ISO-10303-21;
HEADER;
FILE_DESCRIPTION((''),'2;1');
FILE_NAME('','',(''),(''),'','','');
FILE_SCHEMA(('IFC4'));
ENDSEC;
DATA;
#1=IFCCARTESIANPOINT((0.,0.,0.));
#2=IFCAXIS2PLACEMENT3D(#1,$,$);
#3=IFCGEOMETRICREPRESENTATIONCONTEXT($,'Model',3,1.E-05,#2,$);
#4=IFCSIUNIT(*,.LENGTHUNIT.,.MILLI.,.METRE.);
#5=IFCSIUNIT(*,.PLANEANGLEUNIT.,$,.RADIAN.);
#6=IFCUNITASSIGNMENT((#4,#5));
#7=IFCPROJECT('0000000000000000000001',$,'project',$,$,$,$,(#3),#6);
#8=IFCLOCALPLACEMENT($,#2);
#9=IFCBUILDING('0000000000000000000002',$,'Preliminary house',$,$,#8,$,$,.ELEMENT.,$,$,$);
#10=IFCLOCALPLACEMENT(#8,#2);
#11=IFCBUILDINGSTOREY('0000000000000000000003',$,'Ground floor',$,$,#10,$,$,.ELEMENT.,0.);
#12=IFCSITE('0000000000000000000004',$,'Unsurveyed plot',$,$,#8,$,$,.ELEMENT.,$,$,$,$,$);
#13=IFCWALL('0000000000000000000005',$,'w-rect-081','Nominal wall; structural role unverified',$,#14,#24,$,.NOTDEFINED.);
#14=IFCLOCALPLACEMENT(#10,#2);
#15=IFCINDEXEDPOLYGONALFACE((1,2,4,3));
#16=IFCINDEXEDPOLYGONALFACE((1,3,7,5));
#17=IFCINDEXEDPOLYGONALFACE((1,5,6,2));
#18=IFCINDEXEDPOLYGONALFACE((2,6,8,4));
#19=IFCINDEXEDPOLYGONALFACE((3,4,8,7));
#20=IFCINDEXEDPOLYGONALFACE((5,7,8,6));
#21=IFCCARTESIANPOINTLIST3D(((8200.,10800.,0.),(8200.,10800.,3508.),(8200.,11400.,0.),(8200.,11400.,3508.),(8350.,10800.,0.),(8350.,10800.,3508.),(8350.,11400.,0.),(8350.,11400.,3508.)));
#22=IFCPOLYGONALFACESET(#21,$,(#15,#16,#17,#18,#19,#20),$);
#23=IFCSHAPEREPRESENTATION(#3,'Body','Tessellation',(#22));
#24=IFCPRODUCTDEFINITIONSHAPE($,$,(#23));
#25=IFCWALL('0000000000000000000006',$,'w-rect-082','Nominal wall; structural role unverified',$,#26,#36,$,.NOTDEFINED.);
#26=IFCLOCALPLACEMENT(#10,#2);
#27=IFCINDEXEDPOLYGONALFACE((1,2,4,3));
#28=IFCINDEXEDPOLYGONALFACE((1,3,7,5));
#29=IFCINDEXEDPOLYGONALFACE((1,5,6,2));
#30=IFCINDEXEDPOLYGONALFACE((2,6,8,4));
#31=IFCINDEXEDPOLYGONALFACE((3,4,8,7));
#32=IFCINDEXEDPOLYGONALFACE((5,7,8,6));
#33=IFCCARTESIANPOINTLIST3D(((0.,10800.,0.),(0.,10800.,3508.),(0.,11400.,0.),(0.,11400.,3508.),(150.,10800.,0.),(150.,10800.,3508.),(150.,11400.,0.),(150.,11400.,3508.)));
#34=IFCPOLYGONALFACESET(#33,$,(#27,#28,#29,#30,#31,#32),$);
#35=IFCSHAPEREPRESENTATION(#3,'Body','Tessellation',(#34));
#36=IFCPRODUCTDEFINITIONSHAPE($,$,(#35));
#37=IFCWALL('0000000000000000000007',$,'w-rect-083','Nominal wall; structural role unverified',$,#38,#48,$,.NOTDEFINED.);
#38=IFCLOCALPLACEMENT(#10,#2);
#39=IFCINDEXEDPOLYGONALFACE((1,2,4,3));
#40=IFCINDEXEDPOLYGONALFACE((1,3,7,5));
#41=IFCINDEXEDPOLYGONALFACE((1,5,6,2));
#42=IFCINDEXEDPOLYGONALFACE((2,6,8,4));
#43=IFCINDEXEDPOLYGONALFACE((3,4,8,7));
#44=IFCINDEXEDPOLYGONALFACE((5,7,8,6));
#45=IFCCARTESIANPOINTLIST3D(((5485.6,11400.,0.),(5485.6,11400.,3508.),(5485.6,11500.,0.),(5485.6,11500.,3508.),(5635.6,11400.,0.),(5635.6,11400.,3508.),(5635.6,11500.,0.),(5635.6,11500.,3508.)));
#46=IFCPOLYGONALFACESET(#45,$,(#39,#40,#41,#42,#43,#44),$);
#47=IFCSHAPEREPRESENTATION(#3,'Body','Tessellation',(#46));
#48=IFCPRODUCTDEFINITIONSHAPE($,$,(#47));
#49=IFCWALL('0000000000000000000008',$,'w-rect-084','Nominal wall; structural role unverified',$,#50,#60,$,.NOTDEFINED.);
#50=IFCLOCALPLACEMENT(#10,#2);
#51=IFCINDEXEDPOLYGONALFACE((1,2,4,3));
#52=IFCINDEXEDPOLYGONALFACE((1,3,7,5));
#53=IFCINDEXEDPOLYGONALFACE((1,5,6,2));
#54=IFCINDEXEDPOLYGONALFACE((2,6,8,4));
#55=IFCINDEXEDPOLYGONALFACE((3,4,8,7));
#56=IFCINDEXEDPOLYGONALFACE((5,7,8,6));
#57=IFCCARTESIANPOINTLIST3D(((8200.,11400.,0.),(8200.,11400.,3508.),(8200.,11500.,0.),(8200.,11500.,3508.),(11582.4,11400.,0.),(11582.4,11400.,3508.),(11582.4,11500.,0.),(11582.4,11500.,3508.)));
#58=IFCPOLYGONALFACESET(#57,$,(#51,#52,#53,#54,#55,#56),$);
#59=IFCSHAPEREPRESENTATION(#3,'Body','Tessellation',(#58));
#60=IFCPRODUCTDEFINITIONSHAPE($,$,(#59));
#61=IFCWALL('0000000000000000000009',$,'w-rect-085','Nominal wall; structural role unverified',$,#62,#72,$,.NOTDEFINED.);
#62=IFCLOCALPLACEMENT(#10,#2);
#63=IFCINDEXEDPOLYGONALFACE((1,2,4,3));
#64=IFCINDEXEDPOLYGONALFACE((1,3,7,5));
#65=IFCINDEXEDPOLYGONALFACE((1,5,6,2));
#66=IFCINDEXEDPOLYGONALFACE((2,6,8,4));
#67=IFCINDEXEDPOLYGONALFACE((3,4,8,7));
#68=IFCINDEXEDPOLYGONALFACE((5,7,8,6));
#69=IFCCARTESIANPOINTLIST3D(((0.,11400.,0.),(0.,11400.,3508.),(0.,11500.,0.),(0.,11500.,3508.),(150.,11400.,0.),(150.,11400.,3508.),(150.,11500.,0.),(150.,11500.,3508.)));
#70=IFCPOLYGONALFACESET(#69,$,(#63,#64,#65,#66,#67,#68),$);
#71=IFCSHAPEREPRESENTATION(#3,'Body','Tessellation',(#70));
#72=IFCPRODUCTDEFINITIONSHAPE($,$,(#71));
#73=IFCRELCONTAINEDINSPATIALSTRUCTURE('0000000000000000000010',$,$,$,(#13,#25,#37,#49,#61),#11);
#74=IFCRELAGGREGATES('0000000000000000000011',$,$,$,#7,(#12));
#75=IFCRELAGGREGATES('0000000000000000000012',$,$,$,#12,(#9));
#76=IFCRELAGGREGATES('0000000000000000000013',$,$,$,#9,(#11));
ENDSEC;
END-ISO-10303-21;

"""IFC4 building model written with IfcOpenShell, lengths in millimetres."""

from ifc_helpers import new_model, si_unit, origin, place, context, project, spatial, polyline, outline, extrude, element, save


model = new_model("IFC4")

# Units and contexts
model_context = context("Model", 3, precision=1e-05, world=origin())
ifc_project = project(units=[si_unit("LENGTHUNIT", "METRE", prefix="MILLI"), si_unit("PLANEANGLEUNIT", "RADIAN")], contexts=[model_context])

# Site, building, storey
placement_1 = place(None, origin())
site = spatial("IfcSite", under=ifc_project, at=placement_1, Name="Unsurveyed plot", CompositionType="ELEMENT")
building = spatial("IfcBuilding", under=site, at=placement_1, Name="Preliminary house", CompositionType="ELEMENT")
placement_2 = place(placement_1, origin())
storey = spatial("IfcBuildingStorey", under=building, at=placement_2, Name="Ground floor", CompositionType="ELEMENT", Elevation=0.0)

# Walls
element("IfcWall", 1, at=placement_2, inside=storey, Name="w-rect-081", Description="Nominal wall; structural role unverified", PredefinedType="NOTDEFINED", context=model_context, shape_type="SweptSolid", body=[
    extrude(outline(polyline([(8200.0, 10800.0), (8350.0, 10800.0), (8350.0, 11400.0), (8200.0, 11400.0), (8200.0, 10800.0)])), origin(), (0.0, 0.0, 1.0), 3508.0),
])
element("IfcWall", 2, at=placement_2, inside=storey, Name="w-rect-082", Description="Nominal wall; structural role unverified", PredefinedType="NOTDEFINED", context=model_context, shape_type="SweptSolid", body=[
    extrude(outline(polyline([(0.0, 10800.0), (150.0, 10800.0), (150.0, 11400.0), (0.0, 11400.0), (0.0, 10800.0)])), origin(), (0.0, 0.0, 1.0), 3508.0),
])
element("IfcWall", 3, at=placement_2, inside=storey, Name="w-rect-083", Description="Nominal wall; structural role unverified", PredefinedType="NOTDEFINED", context=model_context, shape_type="SweptSolid", body=[
    extrude(outline(polyline([(5485.6, 11400.0), (5635.6, 11400.0), (5635.6, 11500.0), (5485.6, 11500.0), (5485.6, 11400.0)])), origin(), (0.0, 0.0, 1.0), 3508.0),
])
element("IfcWall", 4, at=placement_2, inside=storey, Name="w-rect-084", Description="Nominal wall; structural role unverified", PredefinedType="NOTDEFINED", context=model_context, shape_type="SweptSolid", body=[
    extrude(outline(polyline([(8200.0, 11400.0), (11582.4, 11400.0), (11582.4, 11500.0), (8200.0, 11500.0), (8200.0, 11400.0)])), origin(), (0.0, 0.0, 1.0), 3508.0),
])
element("IfcWall", 5, at=placement_2, inside=storey, Name="w-rect-085", Description="Nominal wall; structural role unverified", PredefinedType="NOTDEFINED", context=model_context, shape_type="SweptSolid", body=[
    extrude(outline(polyline([(0.0, 11400.0), (150.0, 11400.0), (150.0, 11500.0), (0.0, 11500.0), (0.0, 11400.0)])), origin(), (0.0, 0.0, 1.0), 3508.0),
])

save(model, "model.ifc")
